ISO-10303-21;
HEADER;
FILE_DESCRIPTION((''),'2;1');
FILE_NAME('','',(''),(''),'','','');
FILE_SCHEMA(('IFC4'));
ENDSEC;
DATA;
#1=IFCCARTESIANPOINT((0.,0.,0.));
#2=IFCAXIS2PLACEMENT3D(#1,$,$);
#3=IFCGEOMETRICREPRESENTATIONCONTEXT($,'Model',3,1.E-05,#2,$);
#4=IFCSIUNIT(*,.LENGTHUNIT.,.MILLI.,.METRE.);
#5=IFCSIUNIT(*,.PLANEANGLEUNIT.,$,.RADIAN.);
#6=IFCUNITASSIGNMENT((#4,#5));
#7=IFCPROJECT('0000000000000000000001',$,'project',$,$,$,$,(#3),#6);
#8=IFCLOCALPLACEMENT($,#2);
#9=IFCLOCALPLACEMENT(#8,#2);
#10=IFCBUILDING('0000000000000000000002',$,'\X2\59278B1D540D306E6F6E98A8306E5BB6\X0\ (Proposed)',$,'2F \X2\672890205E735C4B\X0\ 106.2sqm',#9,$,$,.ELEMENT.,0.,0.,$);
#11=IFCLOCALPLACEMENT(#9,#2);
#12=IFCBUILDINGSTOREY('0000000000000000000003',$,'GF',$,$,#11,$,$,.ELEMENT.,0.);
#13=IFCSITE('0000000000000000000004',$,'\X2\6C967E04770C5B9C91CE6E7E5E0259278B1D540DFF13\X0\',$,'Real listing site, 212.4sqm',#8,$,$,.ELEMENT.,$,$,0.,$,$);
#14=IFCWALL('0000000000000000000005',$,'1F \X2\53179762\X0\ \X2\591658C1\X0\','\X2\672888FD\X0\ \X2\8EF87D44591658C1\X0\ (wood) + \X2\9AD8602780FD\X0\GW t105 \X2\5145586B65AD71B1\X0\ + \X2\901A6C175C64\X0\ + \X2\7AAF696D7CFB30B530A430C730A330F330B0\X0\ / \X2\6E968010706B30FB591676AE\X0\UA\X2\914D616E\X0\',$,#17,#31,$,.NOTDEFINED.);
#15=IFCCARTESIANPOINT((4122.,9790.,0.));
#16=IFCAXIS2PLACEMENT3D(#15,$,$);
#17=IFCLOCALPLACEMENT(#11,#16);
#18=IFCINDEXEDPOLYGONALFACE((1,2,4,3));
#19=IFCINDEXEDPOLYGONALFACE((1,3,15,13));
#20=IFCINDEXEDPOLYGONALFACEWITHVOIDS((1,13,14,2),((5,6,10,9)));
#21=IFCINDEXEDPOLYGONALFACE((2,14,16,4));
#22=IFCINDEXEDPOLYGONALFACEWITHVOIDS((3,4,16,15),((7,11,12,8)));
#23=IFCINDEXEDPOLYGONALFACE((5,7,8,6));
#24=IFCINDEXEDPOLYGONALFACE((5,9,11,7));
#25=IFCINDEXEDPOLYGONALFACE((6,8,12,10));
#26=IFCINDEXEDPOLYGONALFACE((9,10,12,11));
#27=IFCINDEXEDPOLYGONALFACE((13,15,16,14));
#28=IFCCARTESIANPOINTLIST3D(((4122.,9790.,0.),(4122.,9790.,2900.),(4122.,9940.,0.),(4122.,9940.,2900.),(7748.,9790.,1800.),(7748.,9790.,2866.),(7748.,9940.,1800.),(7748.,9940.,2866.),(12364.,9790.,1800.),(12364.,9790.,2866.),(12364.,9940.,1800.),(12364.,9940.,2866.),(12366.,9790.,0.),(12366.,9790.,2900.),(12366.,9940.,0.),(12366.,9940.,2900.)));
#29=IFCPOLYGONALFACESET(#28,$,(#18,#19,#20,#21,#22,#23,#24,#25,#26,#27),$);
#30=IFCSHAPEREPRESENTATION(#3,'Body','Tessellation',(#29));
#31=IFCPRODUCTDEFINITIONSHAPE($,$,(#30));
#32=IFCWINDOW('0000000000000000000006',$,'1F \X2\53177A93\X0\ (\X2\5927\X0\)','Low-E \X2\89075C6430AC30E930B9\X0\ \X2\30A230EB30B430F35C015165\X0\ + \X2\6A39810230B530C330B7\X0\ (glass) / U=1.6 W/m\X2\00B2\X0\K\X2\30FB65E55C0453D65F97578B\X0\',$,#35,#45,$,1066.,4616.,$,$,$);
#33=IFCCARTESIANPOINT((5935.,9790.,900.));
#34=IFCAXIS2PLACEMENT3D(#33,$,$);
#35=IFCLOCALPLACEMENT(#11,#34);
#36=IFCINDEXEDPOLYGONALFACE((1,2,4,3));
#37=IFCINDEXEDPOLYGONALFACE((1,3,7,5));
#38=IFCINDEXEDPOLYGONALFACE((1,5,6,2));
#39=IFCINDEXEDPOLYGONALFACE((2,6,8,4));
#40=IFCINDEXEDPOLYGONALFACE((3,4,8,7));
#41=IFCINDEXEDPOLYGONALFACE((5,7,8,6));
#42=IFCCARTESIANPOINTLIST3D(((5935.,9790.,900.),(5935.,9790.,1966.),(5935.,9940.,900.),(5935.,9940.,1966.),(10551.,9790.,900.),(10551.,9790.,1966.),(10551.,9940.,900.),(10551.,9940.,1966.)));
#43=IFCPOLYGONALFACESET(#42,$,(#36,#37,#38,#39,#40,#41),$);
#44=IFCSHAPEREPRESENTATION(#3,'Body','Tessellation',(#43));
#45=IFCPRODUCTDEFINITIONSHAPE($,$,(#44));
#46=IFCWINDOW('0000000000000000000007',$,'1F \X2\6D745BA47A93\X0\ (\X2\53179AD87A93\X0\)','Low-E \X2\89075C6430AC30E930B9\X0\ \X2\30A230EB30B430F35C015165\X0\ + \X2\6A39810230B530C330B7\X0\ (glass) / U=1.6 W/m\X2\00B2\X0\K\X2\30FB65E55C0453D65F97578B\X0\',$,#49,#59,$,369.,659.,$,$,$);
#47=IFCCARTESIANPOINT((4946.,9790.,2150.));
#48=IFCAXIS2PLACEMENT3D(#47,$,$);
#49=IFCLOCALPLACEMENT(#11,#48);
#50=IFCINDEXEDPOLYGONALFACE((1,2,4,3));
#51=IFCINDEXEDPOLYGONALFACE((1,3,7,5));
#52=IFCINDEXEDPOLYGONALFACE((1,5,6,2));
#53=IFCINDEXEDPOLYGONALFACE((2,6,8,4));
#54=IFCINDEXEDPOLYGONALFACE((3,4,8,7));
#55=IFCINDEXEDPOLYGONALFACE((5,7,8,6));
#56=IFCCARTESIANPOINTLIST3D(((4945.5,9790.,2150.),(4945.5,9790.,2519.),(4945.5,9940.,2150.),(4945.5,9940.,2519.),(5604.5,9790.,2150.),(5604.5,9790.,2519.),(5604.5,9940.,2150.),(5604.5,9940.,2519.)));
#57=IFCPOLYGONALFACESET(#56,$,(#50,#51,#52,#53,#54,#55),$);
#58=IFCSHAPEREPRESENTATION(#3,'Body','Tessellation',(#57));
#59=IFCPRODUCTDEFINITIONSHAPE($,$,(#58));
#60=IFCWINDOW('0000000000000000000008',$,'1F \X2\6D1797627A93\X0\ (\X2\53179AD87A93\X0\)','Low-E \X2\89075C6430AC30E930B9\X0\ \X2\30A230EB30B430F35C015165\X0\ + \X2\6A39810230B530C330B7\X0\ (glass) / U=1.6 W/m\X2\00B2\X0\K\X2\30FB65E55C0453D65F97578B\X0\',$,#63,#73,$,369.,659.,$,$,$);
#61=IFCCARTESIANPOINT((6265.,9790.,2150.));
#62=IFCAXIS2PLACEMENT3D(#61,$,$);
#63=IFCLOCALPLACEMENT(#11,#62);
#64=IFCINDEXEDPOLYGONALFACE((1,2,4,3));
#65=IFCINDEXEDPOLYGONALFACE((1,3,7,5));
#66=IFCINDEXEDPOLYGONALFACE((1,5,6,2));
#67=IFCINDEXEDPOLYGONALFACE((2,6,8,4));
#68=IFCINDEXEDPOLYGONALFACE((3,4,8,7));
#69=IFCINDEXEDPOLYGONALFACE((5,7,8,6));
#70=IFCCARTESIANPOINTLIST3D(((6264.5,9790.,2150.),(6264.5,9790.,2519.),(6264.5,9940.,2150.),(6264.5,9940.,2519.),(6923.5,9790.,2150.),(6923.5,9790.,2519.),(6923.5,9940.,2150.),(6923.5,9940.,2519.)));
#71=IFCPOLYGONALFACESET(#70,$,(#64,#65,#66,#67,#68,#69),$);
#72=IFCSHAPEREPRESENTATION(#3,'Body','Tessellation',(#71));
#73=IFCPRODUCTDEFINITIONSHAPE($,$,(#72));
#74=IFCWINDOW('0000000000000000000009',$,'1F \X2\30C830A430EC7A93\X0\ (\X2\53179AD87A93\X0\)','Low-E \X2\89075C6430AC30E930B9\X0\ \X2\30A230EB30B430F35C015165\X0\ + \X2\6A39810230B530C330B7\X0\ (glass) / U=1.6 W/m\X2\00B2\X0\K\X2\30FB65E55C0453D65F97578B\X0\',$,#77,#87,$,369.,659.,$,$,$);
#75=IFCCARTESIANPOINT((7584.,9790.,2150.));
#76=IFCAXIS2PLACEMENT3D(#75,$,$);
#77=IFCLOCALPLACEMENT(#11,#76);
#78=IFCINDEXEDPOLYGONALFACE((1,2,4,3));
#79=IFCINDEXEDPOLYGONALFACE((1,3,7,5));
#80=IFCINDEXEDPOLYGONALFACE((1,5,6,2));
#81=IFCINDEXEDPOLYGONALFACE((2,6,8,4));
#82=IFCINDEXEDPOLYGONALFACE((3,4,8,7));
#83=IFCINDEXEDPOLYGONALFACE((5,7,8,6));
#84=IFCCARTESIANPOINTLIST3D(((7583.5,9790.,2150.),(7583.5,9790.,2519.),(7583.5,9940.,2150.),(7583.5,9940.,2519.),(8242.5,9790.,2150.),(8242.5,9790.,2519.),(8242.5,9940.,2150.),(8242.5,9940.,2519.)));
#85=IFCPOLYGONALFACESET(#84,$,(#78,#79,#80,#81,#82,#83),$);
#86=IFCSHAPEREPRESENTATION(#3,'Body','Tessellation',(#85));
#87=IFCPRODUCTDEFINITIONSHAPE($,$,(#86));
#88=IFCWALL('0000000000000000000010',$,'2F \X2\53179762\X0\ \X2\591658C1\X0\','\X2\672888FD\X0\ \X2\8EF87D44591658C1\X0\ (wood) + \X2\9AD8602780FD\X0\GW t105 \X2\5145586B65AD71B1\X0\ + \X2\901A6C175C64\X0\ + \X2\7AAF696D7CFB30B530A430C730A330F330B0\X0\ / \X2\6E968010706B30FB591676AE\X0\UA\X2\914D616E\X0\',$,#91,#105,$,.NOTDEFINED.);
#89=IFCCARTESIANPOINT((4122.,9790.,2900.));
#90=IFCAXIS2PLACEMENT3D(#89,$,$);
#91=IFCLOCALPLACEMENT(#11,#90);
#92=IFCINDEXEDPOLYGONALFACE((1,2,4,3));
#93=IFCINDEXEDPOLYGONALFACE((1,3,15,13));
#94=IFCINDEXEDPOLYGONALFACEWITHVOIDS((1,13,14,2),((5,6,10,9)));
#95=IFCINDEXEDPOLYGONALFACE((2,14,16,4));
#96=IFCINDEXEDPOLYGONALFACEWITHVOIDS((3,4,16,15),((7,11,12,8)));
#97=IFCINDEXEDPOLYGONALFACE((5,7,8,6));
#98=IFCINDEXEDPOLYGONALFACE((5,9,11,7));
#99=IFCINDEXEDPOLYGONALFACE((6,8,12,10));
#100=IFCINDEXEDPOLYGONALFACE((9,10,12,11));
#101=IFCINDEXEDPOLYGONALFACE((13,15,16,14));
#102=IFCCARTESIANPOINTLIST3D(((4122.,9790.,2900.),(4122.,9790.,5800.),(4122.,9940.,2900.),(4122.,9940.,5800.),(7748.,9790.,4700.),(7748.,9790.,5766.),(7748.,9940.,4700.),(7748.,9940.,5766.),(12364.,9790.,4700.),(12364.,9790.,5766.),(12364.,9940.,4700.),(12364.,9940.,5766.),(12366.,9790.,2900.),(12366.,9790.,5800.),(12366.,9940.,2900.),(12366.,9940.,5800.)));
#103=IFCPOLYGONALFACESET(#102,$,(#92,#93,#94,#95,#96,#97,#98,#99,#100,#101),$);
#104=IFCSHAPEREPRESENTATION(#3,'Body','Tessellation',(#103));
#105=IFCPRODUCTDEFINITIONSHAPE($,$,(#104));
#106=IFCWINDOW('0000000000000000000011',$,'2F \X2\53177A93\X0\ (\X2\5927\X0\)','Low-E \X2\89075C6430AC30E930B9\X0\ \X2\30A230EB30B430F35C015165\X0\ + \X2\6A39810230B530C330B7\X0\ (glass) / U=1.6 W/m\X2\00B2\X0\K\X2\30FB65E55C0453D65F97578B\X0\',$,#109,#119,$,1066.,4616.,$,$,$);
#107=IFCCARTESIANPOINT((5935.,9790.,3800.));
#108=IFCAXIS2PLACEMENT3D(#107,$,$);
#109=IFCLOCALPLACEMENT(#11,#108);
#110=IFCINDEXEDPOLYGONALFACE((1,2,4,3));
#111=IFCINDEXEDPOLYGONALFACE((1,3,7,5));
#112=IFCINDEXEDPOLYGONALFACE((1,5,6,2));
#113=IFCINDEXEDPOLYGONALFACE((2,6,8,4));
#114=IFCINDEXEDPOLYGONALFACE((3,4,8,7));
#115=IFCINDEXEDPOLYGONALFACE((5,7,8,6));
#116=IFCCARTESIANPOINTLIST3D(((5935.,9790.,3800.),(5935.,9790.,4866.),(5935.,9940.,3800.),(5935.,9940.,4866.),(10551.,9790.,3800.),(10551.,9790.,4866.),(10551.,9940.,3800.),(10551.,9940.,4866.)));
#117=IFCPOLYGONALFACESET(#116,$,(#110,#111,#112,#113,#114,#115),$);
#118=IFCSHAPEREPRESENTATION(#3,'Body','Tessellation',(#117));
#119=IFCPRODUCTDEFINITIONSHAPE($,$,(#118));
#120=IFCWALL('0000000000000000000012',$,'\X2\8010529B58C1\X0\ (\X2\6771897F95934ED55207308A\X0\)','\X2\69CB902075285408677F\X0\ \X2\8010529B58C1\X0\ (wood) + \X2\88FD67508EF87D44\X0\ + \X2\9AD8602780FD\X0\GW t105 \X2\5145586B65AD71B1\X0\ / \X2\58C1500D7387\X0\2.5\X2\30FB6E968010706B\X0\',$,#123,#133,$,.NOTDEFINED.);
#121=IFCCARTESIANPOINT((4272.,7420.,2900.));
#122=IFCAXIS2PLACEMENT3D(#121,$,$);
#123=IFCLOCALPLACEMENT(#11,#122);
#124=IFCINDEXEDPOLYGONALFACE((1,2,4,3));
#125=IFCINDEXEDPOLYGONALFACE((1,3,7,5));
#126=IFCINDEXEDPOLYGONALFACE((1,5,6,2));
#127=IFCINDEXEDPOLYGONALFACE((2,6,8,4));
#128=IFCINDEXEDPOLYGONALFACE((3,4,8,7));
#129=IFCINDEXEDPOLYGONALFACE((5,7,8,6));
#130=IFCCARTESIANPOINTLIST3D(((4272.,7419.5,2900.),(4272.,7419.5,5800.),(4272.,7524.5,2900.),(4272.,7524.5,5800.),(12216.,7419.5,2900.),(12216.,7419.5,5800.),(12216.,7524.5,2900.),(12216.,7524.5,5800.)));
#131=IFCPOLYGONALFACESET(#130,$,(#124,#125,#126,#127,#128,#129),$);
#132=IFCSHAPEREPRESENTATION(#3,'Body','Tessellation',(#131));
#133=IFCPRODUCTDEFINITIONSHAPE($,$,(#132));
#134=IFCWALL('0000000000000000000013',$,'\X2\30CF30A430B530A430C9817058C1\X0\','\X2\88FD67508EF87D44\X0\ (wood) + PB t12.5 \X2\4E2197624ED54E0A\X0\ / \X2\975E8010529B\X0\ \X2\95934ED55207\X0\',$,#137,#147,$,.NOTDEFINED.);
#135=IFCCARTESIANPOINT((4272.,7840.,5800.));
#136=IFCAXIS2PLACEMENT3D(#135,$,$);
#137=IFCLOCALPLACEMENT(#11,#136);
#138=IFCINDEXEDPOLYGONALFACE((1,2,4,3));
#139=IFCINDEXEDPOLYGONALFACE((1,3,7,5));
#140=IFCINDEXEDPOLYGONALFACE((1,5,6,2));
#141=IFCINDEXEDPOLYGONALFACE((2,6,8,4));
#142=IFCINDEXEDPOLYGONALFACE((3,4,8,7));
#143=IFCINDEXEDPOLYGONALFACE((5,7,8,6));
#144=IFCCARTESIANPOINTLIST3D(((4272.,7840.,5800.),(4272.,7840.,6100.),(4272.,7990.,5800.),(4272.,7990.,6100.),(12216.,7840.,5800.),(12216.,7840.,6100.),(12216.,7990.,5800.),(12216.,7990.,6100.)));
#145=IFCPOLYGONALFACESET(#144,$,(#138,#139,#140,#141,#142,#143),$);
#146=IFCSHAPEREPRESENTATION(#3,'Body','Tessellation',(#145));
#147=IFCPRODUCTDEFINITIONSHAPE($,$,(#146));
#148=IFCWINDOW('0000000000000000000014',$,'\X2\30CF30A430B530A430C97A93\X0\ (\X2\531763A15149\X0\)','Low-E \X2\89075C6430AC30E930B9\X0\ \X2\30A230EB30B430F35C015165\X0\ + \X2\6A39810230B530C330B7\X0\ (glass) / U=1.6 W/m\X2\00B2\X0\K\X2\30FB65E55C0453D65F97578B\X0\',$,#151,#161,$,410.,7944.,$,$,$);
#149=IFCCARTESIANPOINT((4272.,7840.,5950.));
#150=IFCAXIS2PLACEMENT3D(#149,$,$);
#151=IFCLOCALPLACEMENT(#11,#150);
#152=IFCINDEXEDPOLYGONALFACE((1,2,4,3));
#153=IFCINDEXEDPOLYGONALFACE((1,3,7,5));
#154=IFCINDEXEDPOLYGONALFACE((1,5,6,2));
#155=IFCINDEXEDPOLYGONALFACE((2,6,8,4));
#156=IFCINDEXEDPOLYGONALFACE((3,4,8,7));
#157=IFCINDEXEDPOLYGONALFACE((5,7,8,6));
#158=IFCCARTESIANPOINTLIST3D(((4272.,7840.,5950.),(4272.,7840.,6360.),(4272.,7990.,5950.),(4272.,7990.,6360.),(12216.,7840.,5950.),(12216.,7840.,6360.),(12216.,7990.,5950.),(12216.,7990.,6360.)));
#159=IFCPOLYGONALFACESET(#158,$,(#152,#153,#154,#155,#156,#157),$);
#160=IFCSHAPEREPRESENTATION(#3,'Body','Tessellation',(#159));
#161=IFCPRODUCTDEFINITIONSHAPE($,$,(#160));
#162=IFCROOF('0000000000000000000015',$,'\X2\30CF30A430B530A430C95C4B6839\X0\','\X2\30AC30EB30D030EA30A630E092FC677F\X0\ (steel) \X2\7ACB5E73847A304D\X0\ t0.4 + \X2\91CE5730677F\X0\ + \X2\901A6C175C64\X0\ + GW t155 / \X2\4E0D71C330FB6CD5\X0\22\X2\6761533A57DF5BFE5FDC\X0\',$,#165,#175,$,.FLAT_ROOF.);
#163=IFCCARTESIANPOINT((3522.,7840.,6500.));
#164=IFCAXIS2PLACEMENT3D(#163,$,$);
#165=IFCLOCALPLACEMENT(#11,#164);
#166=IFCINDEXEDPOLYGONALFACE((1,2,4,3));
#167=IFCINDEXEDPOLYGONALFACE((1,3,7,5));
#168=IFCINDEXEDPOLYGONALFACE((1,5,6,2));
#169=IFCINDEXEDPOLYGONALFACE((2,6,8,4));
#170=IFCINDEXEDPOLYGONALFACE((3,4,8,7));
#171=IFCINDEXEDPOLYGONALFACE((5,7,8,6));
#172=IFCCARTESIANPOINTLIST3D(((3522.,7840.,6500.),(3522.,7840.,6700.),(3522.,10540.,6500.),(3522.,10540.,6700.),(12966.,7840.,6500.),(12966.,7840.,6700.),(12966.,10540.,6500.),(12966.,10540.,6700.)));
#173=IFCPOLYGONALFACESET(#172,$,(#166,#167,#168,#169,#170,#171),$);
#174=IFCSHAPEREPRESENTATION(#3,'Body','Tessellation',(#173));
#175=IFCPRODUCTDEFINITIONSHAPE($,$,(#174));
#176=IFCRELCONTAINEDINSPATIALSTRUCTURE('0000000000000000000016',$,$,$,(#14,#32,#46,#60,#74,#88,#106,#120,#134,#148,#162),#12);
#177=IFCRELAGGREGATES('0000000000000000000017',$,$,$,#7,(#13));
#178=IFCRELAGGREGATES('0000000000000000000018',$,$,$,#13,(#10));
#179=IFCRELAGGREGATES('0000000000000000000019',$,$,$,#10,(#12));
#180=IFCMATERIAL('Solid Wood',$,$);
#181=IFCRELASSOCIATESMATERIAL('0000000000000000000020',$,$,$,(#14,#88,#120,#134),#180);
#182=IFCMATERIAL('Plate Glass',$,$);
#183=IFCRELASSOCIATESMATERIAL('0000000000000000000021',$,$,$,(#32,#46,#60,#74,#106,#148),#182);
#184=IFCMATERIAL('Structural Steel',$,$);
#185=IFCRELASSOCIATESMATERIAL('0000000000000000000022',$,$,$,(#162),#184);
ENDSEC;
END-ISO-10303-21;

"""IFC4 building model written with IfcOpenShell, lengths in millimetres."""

from ifc_helpers import new_model, si_unit, frame, frame_2d, origin, place, context, project, spatial, rectangle, extrude, material, element, fill, save


model = new_model("IFC4")

# Units and contexts
model_context = context("Model", 3, precision=1e-05, world=origin())
ifc_project = project(units=[si_unit("LENGTHUNIT", "METRE", prefix="MILLI"), si_unit("PLANEANGLEUNIT", "RADIAN")], contexts=[model_context])

# Site, building, storey
site_placement = place(None, origin())
site = spatial("IfcSite", under=ifc_project, at=site_placement, Name="沖縄県宜野湾市大謝名３", ObjectType="Real listing site, 212.4sqm", CompositionType="ELEMENT", RefElevation=0.0)
building_placement = place(site_placement, origin())
building = spatial("IfcBuilding", under=site, at=building_placement, Name="大謝名の潮風の家 (Proposed)", ObjectType="2F 木造平屋 106.2sqm", CompositionType="ELEMENT", ElevationOfRefHeight=0.0, ElevationOfTerrain=0.0)
storey_placement = place(building_placement, origin())
storey = spatial("IfcBuildingStorey", under=building, at=storey_placement, Name="GF", CompositionType="ELEMENT", Elevation=0.0)

# Wall, openings, windows
ifc_material_1 = material(Name="Solid Wood")
wall_1_placement = place(storey_placement, frame((4122.0, 9790.0, 0.0)))
wall_1 = element("IfcWall", 1, at=wall_1_placement, inside=storey, material=ifc_material_1, Name="1F 北面 外壁", Description="木製 軸組外壁 (wood) + 高性能GW t105 充填断熱 + 通気層 + 窯業系サイディング / 準耐火・外皮UA配慮", PredefinedType="NOTDEFINED", context=model_context, shape_type="SweptSolid", body=[
    extrude(rectangle(XDim=8244.0, YDim=150.0, at=frame_2d((4122.0, 75.0))), frame((4122.0, 9790.0, 0.0)), (0.0, 0.0, 1.0), 2900.0),
])
opening_1_placement = place(storey_placement, frame((5935.0, 9790.0, 900.0)))
opening_1 = element("IfcOpeningElement", 2, at=opening_1_placement, cuts=wall_1, PredefinedType="NOTDEFINED", context=model_context, shape_type="SweptSolid", body=[
    extrude(rectangle(XDim=4616.0, YDim=150.0, at=frame_2d((2308.0, 75.0))), frame((5935.0, 9790.0, 900.0)), (0.0, 0.0, 1.0), 1066.0),
])
opening_2_placement = place(storey_placement, frame((4946.0, 9790.0, 2150.0)))
opening_2 = element("IfcOpeningElement", 3, at=opening_2_placement, cuts=wall_1, PredefinedType="NOTDEFINED", context=model_context, shape_type="SweptSolid", body=[
    extrude(rectangle(XDim=659.0, YDim=150.0, at=frame_2d((329.0, 75.0))), frame((4946.0, 9790.0, 2150.0)), (0.0, 0.0, 1.0), 369.0),
])
opening_3_placement = place(storey_placement, frame((6265.0, 9790.0, 2150.0)))
opening_3 = element("IfcOpeningElement", 4, at=opening_3_placement, cuts=wall_1, PredefinedType="NOTDEFINED", context=model_context, shape_type="SweptSolid", body=[
    extrude(rectangle(XDim=659.0, YDim=150.0, at=frame_2d((329.0, 75.0))), frame((6265.0, 9790.0, 2150.0)), (0.0, 0.0, 1.0), 369.0),
])
opening_4_placement = place(storey_placement, frame((7584.0, 9790.0, 2150.0)))
opening_4 = element("IfcOpeningElement", 5, at=opening_4_placement, cuts=wall_1, PredefinedType="NOTDEFINED", context=model_context, shape_type="SweptSolid", body=[
    extrude(rectangle(XDim=659.0, YDim=150.0, at=frame_2d((329.0, 75.0))), frame((7584.0, 9790.0, 2150.0)), (0.0, 0.0, 1.0), 369.0),
])
ifc_material_2 = material(Name="Plate Glass")
window_1_placement = place(storey_placement, frame((5935.0, 9790.0, 900.0)))
window_1 = element("IfcWindow", 6, at=window_1_placement, inside=storey, material=ifc_material_2, Name="1F 北窓 (大)", Description="Low-E 複層ガラス アルゴン封入 + 樹脂サッシ (glass) / U=1.6 W/m²K・日射取得型", OverallHeight=1066.0, OverallWidth=4616.0, context=model_context, shape_type="SweptSolid", body=[
    extrude(rectangle(XDim=4616.0, YDim=150.0, at=frame_2d((2308.0, 75.0))), frame((5935.0, 9790.0, 900.0)), (0.0, 0.0, 1.0), 1066.0),
])
fill(opening_1, window_1)
window_2_placement = place(storey_placement, frame((4946.0, 9790.0, 2150.0)))
window_2 = element("IfcWindow", 7, at=window_2_placement, inside=storey, material=ifc_material_2, Name="1F 浴室窓 (北高窓)", Description="Low-E 複層ガラス アルゴン封入 + 樹脂サッシ (glass) / U=1.6 W/m²K・日射取得型", OverallHeight=369.0, OverallWidth=659.0, context=model_context, shape_type="SweptSolid", body=[
    extrude(rectangle(XDim=659.0, YDim=150.0, at=frame_2d((329.0, 75.0))), frame((4946.0, 9790.0, 2150.0)), (0.0, 0.0, 1.0), 369.0),
])
fill(opening_2, window_2)
window_3_placement = place(storey_placement, frame((6265.0, 9790.0, 2150.0)))
window_3 = element("IfcWindow", 8, at=window_3_placement, inside=storey, material=ifc_material_2, Name="1F 洗面窓 (北高窓)", Description="Low-E 複層ガラス アルゴン封入 + 樹脂サッシ (glass) / U=1.6 W/m²K・日射取得型", OverallHeight=369.0, OverallWidth=659.0, context=model_context, shape_type="SweptSolid", body=[
    extrude(rectangle(XDim=659.0, YDim=150.0, at=frame_2d((329.0, 75.0))), frame((6265.0, 9790.0, 2150.0)), (0.0, 0.0, 1.0), 369.0),
])
fill(opening_3, window_3)
window_4_placement = place(storey_placement, frame((7584.0, 9790.0, 2150.0)))
window_4 = element("IfcWindow", 9, at=window_4_placement, inside=storey, material=ifc_material_2, Name="1F トイレ窓 (北高窓)", Description="Low-E 複層ガラス アルゴン封入 + 樹脂サッシ (glass) / U=1.6 W/m²K・日射取得型", OverallHeight=369.0, OverallWidth=659.0, context=model_context, shape_type="SweptSolid", body=[
    extrude(rectangle(XDim=659.0, YDim=150.0, at=frame_2d((329.0, 75.0))), frame((7584.0, 9790.0, 2150.0)), (0.0, 0.0, 1.0), 369.0),
])
fill(opening_4, window_4)

# Wall, opening, window
wall_2_placement = place(storey_placement, frame((4122.0, 9790.0, 2900.0)))
wall_2 = element("IfcWall", 10, at=wall_2_placement, inside=storey, material=ifc_material_1, Name="2F 北面 外壁", Description="木製 軸組外壁 (wood) + 高性能GW t105 充填断熱 + 通気層 + 窯業系サイディング / 準耐火・外皮UA配慮", PredefinedType="NOTDEFINED", context=model_context, shape_type="SweptSolid", body=[
    extrude(rectangle(XDim=8244.0, YDim=150.0, at=frame_2d((4122.0, 75.0))), frame((4122.0, 9790.0, 2900.0)), (0.0, 0.0, 1.0), 2900.0),
])
opening_5_placement = place(storey_placement, frame((5935.0, 9790.0, 3800.0)))
opening_5 = element("IfcOpeningElement", 11, at=opening_5_placement, cuts=wall_2, PredefinedType="NOTDEFINED", context=model_context, shape_type="SweptSolid", body=[
    extrude(rectangle(XDim=4616.0, YDim=150.0, at=frame_2d((2308.0, 75.0))), frame((5935.0, 9790.0, 3800.0)), (0.0, 0.0, 1.0), 1066.0),
])
window_5_placement = place(storey_placement, frame((5935.0, 9790.0, 3800.0)))
window_5 = element("IfcWindow", 12, at=window_5_placement, inside=storey, material=ifc_material_2, Name="2F 北窓 (大)", Description="Low-E 複層ガラス アルゴン封入 + 樹脂サッシ (glass) / U=1.6 W/m²K・日射取得型", OverallHeight=1066.0, OverallWidth=4616.0, context=model_context, shape_type="SweptSolid", body=[
    extrude(rectangle(XDim=4616.0, YDim=150.0, at=frame_2d((2308.0, 75.0))), frame((5935.0, 9790.0, 3800.0)), (0.0, 0.0, 1.0), 1066.0),
])
fill(opening_5, window_5)

# Wall
wall_3_placement = place(storey_placement, frame((4272.0, 7420.0, 2900.0)))
element("IfcWall", 13, at=wall_3_placement, inside=storey, material=ifc_material_1, Name="耐力壁 (東西間仕切り)", Description="構造用合板 耐力壁 (wood) + 製材軸組 + 高性能GW t105 充填断熱 / 壁倍率2.5・準耐火", PredefinedType="NOTDEFINED", context=model_context, shape_type="SweptSolid", body=[
    extrude(rectangle(XDim=7944.0, YDim=105.0, at=frame_2d((3972.0, 52.0))), frame((4272.0, 7420.0, 2900.0)), (0.0, 0.0, 1.0), 2900.0),
])

# Wall, opening, window
wall_4_placement = place(storey_placement, frame((4272.0, 7840.0, 5800.0)))
wall_4 = element("IfcWall", 14, at=wall_4_placement, inside=storey, material=ifc_material_1, Name="ハイサイド腰壁", Description="製材軸組 (wood) + PB t12.5 両面仕上 / 非耐力 間仕切", PredefinedType="NOTDEFINED", context=model_context, shape_type="SweptSolid", body=[
    extrude(rectangle(XDim=7944.0, YDim=150.0, at=frame_2d((3972.0, 75.0))), frame((4272.0, 7840.0, 5800.0)), (0.0, 0.0, 1.0), 700.0),
])
opening_6_placement = place(storey_placement, frame((4272.0, 7840.0, 5950.0)))
opening_6 = element("IfcOpeningElement", 15, at=opening_6_placement, cuts=wall_4, PredefinedType="NOTDEFINED", context=model_context, shape_type="SweptSolid", body=[
    extrude(rectangle(XDim=7944.0, YDim=150.0, at=frame_2d((3972.0, 75.0))), frame((4272.0, 7840.0, 5950.0)), (0.0, 0.0, 1.0), 410.0),
])
window_6_placement = place(storey_placement, frame((4272.0, 7840.0, 5950.0)))
window_6 = element("IfcWindow", 16, at=window_6_placement, inside=storey, material=ifc_material_2, Name="ハイサイド窓 (北採光)", Description="Low-E 複層ガラス アルゴン封入 + 樹脂サッシ (glass) / U=1.6 W/m²K・日射取得型", OverallHeight=410.0, OverallWidth=7944.0, context=model_context, shape_type="SweptSolid", body=[
    extrude(rectangle(XDim=7944.0, YDim=150.0, at=frame_2d((3972.0, 75.0))), frame((4272.0, 7840.0, 5950.0)), (0.0, 0.0, 1.0), 410.0),
])
fill(opening_6, window_6)

# Roof
ifc_material_3 = material(Name="Structural Steel")
roof_placement = place(storey_placement, frame((3522.0, 7840.0, 6500.0)))
element("IfcRoof", 17, at=roof_placement, inside=storey, material=ifc_material_3, Name="ハイサイド屋根", Description="ガルバリウム鋼板 (steel) 立平葺き t0.4 + 野地板 + 通気層 + GW t155 / 不燃・法22条区域対応", PredefinedType="FLAT_ROOF", context=model_context, shape_type="SweptSolid", body=[
    extrude(rectangle(XDim=9444.0, YDim=2700.0, at=frame_2d((4722.0, 1350.0))), frame((3522.0, 7840.0, 6500.0)), (0.0, 0.0, 1.0), 200.0),
])

save(model, "model.ifc")
